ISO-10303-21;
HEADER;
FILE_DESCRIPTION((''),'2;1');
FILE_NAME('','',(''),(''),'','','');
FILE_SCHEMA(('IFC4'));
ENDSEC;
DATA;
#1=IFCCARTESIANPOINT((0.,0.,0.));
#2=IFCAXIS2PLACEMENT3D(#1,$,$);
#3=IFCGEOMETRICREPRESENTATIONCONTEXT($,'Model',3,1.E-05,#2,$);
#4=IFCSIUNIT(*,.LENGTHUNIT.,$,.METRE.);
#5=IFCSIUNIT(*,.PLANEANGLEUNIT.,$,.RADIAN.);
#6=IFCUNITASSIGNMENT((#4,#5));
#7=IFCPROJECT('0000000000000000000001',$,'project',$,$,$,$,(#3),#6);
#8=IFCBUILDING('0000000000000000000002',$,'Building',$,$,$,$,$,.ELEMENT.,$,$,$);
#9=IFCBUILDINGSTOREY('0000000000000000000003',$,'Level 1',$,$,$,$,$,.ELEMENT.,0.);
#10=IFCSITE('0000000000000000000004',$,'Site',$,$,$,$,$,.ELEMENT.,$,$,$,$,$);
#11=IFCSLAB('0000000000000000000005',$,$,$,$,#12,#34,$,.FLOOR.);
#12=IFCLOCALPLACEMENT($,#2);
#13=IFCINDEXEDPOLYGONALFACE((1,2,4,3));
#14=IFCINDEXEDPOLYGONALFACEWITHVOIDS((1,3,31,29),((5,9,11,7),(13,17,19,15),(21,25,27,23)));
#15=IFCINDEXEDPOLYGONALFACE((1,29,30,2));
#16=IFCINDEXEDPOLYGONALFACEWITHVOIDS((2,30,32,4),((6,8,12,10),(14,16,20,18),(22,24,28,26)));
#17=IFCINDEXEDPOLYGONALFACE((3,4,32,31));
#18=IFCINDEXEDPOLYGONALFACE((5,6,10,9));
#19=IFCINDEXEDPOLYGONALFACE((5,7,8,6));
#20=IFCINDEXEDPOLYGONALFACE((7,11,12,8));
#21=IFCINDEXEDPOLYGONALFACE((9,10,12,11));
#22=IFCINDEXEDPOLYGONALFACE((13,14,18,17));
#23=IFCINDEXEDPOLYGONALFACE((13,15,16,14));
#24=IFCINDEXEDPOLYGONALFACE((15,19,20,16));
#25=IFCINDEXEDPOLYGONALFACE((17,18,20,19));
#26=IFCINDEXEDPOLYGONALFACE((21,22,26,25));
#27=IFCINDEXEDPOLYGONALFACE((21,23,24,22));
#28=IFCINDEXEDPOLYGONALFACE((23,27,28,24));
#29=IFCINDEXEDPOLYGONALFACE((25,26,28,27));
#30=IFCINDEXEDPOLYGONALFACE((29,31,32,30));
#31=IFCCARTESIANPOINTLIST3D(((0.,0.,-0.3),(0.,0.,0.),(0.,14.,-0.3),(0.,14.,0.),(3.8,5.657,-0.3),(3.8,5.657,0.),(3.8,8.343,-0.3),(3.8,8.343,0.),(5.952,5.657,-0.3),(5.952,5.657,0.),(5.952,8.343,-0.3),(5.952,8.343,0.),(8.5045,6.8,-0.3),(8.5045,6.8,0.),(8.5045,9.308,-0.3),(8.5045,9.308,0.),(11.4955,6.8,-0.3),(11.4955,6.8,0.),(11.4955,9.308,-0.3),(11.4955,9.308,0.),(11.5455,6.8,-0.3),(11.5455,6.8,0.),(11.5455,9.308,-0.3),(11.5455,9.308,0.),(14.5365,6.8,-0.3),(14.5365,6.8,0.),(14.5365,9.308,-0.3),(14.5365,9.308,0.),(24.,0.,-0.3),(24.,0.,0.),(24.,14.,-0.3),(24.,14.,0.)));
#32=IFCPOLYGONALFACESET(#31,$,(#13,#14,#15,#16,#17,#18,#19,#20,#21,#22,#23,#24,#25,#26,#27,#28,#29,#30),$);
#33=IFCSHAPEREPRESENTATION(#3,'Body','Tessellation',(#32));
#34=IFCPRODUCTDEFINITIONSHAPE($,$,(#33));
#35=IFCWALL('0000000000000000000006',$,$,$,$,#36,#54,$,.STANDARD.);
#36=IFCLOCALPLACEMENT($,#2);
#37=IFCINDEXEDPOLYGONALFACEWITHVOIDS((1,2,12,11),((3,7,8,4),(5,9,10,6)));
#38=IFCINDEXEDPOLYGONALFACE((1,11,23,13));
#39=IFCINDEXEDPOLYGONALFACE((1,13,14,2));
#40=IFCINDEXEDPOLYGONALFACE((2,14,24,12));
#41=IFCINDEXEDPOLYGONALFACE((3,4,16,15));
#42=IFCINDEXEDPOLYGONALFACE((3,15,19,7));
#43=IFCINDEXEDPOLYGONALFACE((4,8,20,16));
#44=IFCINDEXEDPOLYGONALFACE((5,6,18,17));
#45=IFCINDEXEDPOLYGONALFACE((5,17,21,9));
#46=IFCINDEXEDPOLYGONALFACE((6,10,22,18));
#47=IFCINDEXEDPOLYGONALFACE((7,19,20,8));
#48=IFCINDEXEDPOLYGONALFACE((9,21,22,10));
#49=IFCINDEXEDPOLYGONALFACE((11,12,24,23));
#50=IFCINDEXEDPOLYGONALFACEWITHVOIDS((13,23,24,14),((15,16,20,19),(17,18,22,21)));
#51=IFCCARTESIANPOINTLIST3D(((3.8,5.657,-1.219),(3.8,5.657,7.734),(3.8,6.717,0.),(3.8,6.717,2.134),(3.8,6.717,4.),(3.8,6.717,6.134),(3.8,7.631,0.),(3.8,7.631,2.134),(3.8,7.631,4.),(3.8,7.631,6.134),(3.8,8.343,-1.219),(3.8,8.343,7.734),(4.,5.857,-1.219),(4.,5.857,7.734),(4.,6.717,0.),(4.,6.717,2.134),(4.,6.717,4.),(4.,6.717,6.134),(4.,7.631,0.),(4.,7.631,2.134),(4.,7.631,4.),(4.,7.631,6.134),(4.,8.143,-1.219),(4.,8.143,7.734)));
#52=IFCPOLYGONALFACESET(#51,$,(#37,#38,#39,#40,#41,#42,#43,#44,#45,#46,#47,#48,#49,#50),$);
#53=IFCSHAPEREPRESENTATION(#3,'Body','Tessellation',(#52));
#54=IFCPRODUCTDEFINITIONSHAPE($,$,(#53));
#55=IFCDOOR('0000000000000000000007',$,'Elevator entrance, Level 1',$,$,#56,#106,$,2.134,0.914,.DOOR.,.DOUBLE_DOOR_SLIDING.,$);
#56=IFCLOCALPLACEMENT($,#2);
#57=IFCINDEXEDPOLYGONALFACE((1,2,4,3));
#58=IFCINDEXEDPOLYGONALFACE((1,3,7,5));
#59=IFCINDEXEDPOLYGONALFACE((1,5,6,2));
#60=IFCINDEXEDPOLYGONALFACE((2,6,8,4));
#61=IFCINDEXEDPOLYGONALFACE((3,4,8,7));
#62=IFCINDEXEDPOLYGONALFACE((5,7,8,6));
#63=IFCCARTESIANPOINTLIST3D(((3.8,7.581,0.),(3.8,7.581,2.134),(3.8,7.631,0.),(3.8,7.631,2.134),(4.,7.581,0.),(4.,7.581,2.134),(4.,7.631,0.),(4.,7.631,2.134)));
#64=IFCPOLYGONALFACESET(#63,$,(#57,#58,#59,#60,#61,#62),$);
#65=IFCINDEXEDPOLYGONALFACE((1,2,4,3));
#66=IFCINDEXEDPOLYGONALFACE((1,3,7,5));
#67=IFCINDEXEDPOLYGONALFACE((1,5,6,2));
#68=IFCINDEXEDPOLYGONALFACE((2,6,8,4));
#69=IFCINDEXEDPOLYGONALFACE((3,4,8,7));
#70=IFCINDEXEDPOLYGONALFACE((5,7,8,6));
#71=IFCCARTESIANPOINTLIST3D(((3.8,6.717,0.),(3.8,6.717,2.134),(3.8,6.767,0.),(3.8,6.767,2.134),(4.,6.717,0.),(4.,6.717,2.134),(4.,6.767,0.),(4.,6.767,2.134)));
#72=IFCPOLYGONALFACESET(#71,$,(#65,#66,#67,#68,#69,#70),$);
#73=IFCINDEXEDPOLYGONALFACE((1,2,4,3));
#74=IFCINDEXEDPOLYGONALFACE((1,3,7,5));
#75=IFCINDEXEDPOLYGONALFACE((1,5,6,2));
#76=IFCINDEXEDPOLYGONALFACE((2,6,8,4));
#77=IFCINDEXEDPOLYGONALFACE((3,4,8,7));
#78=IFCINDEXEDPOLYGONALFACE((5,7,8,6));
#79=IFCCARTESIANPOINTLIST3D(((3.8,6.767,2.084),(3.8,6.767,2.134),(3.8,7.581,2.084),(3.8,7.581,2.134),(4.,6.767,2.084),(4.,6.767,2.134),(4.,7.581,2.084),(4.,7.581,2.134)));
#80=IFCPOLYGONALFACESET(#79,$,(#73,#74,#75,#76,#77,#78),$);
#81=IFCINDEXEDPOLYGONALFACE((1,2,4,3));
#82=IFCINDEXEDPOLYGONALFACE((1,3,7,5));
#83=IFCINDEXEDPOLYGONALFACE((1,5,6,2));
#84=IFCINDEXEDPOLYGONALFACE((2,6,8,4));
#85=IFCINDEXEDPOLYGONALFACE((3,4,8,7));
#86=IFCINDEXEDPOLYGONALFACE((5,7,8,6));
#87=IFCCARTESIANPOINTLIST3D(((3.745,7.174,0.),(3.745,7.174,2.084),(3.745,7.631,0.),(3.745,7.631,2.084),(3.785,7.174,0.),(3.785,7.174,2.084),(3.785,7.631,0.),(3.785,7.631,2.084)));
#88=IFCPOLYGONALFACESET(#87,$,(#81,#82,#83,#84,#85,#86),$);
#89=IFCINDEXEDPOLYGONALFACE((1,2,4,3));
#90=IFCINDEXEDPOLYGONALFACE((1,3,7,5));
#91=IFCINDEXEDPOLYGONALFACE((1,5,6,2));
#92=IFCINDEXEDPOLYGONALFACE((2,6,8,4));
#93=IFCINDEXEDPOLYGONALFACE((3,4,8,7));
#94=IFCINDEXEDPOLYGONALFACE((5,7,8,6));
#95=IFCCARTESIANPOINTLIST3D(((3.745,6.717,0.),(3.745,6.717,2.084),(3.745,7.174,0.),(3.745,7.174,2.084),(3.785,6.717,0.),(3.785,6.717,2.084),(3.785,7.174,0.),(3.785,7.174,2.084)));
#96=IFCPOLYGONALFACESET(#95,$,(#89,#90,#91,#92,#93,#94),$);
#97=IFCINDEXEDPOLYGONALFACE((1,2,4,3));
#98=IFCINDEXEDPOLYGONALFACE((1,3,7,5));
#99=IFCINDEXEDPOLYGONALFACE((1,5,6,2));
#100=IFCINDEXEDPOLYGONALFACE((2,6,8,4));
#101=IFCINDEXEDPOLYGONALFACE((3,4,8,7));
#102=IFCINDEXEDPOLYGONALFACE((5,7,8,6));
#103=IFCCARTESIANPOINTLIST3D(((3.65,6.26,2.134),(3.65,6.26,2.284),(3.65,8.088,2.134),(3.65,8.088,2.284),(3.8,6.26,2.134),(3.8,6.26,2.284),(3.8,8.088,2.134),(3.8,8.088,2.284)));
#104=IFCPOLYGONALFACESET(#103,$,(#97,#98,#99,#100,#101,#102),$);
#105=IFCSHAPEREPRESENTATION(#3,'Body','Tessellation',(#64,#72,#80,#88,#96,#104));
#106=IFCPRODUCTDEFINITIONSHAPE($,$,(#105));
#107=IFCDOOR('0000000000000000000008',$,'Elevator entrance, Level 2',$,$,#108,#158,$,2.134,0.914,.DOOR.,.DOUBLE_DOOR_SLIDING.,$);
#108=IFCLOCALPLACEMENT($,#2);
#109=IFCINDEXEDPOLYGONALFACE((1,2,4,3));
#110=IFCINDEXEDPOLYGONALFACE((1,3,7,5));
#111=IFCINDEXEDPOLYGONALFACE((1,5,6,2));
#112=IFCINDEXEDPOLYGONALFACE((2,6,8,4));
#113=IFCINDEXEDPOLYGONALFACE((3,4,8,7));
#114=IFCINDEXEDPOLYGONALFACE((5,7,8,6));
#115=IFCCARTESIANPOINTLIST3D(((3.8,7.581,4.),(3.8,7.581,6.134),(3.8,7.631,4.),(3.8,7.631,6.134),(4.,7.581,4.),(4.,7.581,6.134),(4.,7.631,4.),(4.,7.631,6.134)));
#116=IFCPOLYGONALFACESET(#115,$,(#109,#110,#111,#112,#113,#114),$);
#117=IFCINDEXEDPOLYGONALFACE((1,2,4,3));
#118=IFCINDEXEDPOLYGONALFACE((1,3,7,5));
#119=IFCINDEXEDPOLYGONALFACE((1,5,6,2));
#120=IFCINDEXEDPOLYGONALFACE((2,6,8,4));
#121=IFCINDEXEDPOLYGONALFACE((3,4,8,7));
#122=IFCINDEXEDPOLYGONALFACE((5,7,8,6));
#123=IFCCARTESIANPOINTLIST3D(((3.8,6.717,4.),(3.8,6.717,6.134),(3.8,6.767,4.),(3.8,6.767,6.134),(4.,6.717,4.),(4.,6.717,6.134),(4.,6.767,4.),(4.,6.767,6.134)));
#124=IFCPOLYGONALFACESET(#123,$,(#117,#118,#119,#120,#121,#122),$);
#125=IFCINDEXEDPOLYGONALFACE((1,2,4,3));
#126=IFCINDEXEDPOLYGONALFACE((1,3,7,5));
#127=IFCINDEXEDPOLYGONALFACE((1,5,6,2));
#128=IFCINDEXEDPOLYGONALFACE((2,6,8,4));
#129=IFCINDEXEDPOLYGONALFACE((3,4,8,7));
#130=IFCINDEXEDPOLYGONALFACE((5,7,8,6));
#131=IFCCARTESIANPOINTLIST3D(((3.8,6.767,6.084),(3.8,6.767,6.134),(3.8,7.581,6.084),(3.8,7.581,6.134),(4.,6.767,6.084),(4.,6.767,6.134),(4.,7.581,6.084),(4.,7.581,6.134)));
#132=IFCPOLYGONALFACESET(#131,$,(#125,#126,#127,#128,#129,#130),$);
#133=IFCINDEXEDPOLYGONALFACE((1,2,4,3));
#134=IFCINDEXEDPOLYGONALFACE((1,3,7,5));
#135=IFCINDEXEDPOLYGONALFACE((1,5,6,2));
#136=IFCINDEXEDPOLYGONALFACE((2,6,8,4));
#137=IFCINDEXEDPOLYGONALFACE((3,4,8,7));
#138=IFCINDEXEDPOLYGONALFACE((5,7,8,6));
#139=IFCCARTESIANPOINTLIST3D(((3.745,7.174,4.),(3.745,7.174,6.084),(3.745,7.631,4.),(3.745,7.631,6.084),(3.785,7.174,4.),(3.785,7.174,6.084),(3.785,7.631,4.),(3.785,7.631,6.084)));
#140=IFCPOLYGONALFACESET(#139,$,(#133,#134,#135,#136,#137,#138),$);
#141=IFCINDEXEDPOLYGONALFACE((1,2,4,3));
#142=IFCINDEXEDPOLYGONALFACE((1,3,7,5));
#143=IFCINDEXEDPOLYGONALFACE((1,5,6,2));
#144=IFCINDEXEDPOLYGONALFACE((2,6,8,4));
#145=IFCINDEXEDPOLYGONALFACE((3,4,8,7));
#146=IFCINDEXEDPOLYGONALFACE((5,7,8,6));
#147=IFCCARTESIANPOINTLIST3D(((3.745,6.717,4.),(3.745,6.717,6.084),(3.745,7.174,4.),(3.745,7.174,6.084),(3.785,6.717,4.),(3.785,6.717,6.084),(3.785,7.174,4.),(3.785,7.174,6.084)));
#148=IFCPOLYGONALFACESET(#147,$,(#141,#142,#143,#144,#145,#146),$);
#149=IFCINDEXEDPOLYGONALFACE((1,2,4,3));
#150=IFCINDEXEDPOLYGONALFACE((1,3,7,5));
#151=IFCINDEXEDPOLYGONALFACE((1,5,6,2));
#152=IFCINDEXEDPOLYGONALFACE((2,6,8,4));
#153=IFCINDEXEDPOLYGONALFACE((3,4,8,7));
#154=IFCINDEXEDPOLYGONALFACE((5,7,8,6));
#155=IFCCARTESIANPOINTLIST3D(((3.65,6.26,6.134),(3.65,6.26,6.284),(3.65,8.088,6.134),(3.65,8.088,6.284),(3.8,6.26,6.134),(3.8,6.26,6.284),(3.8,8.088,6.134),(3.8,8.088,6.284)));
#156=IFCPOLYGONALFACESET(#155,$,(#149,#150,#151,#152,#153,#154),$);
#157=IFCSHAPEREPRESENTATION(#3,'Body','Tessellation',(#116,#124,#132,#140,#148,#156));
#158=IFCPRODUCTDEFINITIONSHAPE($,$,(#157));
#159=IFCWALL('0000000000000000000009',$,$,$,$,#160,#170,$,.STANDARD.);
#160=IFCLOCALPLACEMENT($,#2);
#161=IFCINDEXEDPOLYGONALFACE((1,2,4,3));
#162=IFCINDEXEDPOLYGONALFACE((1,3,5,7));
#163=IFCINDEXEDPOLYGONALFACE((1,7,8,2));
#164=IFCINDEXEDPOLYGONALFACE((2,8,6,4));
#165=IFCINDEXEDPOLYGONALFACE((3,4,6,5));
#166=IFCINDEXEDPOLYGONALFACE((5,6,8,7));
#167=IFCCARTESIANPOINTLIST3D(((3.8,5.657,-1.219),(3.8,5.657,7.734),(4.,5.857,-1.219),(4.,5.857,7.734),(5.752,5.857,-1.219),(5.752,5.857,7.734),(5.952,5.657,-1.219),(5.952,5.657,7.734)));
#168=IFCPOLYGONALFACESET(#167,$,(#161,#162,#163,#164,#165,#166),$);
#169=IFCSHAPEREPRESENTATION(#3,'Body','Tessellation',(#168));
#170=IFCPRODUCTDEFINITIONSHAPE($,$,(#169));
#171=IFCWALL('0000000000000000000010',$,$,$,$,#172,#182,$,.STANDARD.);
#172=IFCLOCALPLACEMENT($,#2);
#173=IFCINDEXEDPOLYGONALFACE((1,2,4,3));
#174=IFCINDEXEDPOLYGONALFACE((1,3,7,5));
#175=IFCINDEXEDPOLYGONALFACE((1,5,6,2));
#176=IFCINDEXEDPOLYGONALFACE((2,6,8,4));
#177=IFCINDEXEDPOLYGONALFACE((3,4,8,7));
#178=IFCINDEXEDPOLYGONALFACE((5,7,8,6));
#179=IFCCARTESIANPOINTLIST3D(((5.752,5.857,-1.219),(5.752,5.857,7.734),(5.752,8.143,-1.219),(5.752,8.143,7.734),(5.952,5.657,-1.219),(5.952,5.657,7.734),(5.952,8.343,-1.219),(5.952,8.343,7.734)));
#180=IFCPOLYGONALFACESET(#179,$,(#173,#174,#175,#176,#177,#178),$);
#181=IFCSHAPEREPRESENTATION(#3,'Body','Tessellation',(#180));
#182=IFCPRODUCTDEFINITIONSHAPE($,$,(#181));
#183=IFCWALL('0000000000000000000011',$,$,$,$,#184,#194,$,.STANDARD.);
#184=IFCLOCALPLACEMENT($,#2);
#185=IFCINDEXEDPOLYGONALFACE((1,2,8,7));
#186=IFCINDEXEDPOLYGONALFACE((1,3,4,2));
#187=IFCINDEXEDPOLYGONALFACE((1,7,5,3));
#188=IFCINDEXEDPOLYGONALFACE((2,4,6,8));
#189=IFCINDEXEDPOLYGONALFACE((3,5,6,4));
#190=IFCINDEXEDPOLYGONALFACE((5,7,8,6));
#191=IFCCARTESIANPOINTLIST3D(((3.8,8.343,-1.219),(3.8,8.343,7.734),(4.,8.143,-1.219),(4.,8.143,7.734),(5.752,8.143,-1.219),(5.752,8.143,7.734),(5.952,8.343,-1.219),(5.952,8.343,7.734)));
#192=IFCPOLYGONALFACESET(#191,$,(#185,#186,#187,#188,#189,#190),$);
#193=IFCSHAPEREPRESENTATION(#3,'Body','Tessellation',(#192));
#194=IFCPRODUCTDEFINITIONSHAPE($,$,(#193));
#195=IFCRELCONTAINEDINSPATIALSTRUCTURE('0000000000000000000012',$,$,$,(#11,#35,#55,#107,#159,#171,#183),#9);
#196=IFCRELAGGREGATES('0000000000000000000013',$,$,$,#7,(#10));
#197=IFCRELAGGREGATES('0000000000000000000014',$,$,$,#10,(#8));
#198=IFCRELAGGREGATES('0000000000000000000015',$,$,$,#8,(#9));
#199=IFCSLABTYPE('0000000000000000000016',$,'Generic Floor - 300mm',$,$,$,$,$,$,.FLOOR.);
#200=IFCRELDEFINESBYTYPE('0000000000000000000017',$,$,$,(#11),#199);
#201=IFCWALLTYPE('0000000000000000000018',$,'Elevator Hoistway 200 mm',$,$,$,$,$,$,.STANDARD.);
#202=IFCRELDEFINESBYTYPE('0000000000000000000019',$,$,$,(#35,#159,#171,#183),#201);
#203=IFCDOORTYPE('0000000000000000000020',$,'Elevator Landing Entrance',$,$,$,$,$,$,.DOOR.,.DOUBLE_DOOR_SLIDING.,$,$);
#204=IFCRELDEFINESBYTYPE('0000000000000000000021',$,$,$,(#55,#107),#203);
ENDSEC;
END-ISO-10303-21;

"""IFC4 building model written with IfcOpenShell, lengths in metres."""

from ifc_helpers import new_model, si_unit, frame, frame_2d, origin, origin_with_axes, origin_2d, place, context, project, spatial, polyline, rectangle, outline, extrude, type_object, element, fill, save


model = new_model("IFC4")

# Units and contexts
model_context = context("Model", 3, precision=1e-05, world=origin())
ifc_project = project(units=[si_unit("LENGTHUNIT", "METRE"), si_unit("PLANEANGLEUNIT", "RADIAN")], contexts=[model_context])

# Site, building, storey
site = spatial("IfcSite", under=ifc_project, Name="Site", CompositionType="ELEMENT")
building = spatial("IfcBuilding", under=site, Name="Building", CompositionType="ELEMENT")
storey = spatial("IfcBuildingStorey", under=building, Name="Level 1", CompositionType="ELEMENT", Elevation=0.0)

# Slab, openings
slab_type = type_object("IfcSlabType", Name="Generic Floor - 300mm", PredefinedType="FLOOR")
slab_placement = place(None, origin())
slab = element("IfcSlab", 1, at=slab_placement, inside=storey, type_object=slab_type, PredefinedType="FLOOR", context=model_context, shape_type="SweptSolid", body=[
    extrude(outline(polyline([(0.0, 0.0), (24.0, 0.0), (24.0, 14.0), (0.0, 14.0), (0.0, 0.0)])), origin(), (0.0, 0.0, -1.0), 0.3),
])
opening_1_placement = place(None, frame((0.0, 0.0, 0.001)))
element("IfcOpeningElement", 2, at=opening_1_placement, cuts=slab, PredefinedType="OPENING", context=model_context, shape_type="SweptSolid", body=[
    extrude(outline(polyline([(8.5045, 6.8), (11.4955, 6.8), (11.4955, 9.308), (8.5045, 9.308), (8.5045, 6.8)])), origin(), (0.0, 0.0, -1.0), 0.302),
])
opening_2_placement = place(None, frame((0.0, 0.0, 0.001)))
element("IfcOpeningElement", 3, at=opening_2_placement, cuts=slab, PredefinedType="OPENING", context=model_context, shape_type="SweptSolid", body=[
    extrude(outline(polyline([(11.5455, 6.8), (14.5365, 6.8), (14.5365, 9.308), (11.5455, 9.308), (11.5455, 6.8)])), origin(), (0.0, 0.0, -1.0), 0.302),
])
opening_3_placement = place(None, frame((0.0, 0.0, 0.001)))
element("IfcOpeningElement", 4, at=opening_3_placement, cuts=slab, PredefinedType="OPENING", context=model_context, shape_type="SweptSolid", body=[
    extrude(outline(polyline([(3.8, 8.343), (3.8, 5.657), (5.952, 5.657), (5.952, 8.343), (3.8, 8.343)])), origin(), (0.0, 0.0, -1.0), 0.302),
])

# Wall, openings, doors
wall_type = type_object("IfcWallType", Name="Elevator Hoistway 200 mm", PredefinedType="STANDARD")
wall_1_placement = place(None, frame((3.9, 8.243, -1.219), z_axis=(0.0, 0.0, 1.0), x_axis=(0.0, -1.0, 0.0)))
wall_1 = element("IfcWall", 5, at=wall_1_placement, inside=storey, type_object=wall_type, PredefinedType="STANDARD", context=model_context, shape_type="SweptSolid", body=[
    extrude(outline(polyline([(-0.1, -0.1), (2.586, -0.1), (2.386, 0.1), (0.1, 0.1), (-0.1, -0.1)])), origin(), (0.0, 0.0, 1.0), 8.953),
])
opening_4_placement = place(wall_1_placement, frame((1.069, 0.0, 1.219), z_axis=(0.0, 0.0, 1.0), x_axis=(1.0, 0.0, 0.0)))
opening_4 = element("IfcOpeningElement", 6, at=opening_4_placement, cuts=wall_1, PredefinedType="OPENING", context=model_context, shape_type="SweptSolid", body=[
    extrude(rectangle(XDim=0.914, YDim=0.202, at=origin_2d()), origin(), (0.0, 0.0, 1.0), 2.134),
])
opening_5_placement = place(wall_1_placement, frame((1.069, 0.0, 5.219), z_axis=(0.0, 0.0, 1.0), x_axis=(1.0, 0.0, 0.0)))
opening_5 = element("IfcOpeningElement", 7, at=opening_5_placement, cuts=wall_1, PredefinedType="OPENING", context=model_context, shape_type="SweptSolid", body=[
    extrude(rectangle(XDim=0.914, YDim=0.202, at=origin_2d()), origin(), (0.0, 0.0, 1.0), 2.134),
])
door_type = type_object("IfcDoorType", Name="Elevator Landing Entrance", OperationType="DOUBLE_DOOR_SLIDING", PredefinedType="DOOR")
door_1_placement = place(opening_4_placement, origin_with_axes())
door_1 = element("IfcDoor", 8, at=door_1_placement, inside=storey, type_object=door_type, Name="Elevator entrance, Level 1", OperationType="DOUBLE_DOOR_SLIDING", OverallHeight=2.134, OverallWidth=0.914, PredefinedType="DOOR", context=model_context, shape_type="SweptSolid", body=[
    extrude(rectangle(XDim=0.05, YDim=0.2, at=frame_2d((-0.432, 0.0))), origin(), (0.0, 0.0, 1.0), 2.134),
    extrude(rectangle(XDim=0.05, YDim=0.2, at=frame_2d((0.432, 0.0))), origin(), (0.0, 0.0, 1.0), 2.134),
    extrude(rectangle(XDim=0.814, YDim=0.2, at=origin_2d()), frame((0.0, 0.0, 2.084)), (0.0, 0.0, 1.0), 0.05),
    extrude(rectangle(XDim=0.457, YDim=0.04, at=frame_2d((-0.2285, -0.135))), origin(), (0.0, 0.0, 1.0), 2.084),
    extrude(rectangle(XDim=0.457, YDim=0.04, at=frame_2d((0.2285, -0.135))), origin(), (0.0, 0.0, 1.0), 2.084),
    extrude(rectangle(XDim=1.828, YDim=0.15, at=frame_2d((0.0, -0.175))), frame((0.0, 0.0, 2.134)), (0.0, 0.0, 1.0), 0.15),
])
fill(opening_4, door_1)
door_2_placement = place(opening_5_placement, origin_with_axes())
door_2 = element("IfcDoor", 9, at=door_2_placement, inside=storey, type_object=door_type, Name="Elevator entrance, Level 2", OperationType="DOUBLE_DOOR_SLIDING", OverallHeight=2.134, OverallWidth=0.914, PredefinedType="DOOR", context=model_context, shape_type="SweptSolid", body=[
    extrude(rectangle(XDim=0.05, YDim=0.2, at=frame_2d((-0.432, 0.0))), origin(), (0.0, 0.0, 1.0), 2.134),
    extrude(rectangle(XDim=0.05, YDim=0.2, at=frame_2d((0.432, 0.0))), origin(), (0.0, 0.0, 1.0), 2.134),
    extrude(rectangle(XDim=0.814, YDim=0.2, at=origin_2d()), frame((0.0, 0.0, 2.084)), (0.0, 0.0, 1.0), 0.05),
    extrude(rectangle(XDim=0.457, YDim=0.04, at=frame_2d((-0.2285, -0.135))), origin(), (0.0, 0.0, 1.0), 2.084),
    extrude(rectangle(XDim=0.457, YDim=0.04, at=frame_2d((0.2285, -0.135))), origin(), (0.0, 0.0, 1.0), 2.084),
    extrude(rectangle(XDim=1.828, YDim=0.15, at=frame_2d((0.0, -0.175))), frame((0.0, 0.0, 2.134)), (0.0, 0.0, 1.0), 0.15),
])
fill(opening_5, door_2)

# Walls
wall_2_placement = place(None, frame((3.9, 5.757, -1.219), z_axis=(0.0, 0.0, 1.0), x_axis=(1.0, 0.0, 0.0)))
element("IfcWall", 10, at=wall_2_placement, inside=storey, type_object=wall_type, PredefinedType="STANDARD", context=model_context, shape_type="SweptSolid", body=[
    extrude(outline(polyline([(-0.1, -0.1), (2.052, -0.1), (1.852, 0.1), (0.1, 0.1), (-0.1, -0.1)])), origin(), (0.0, 0.0, 1.0), 8.953),
])
wall_3_placement = place(None, frame((5.852, 5.757, -1.219), z_axis=(0.0, 0.0, 1.0), x_axis=(0.0, 1.0, 0.0)))
element("IfcWall", 11, at=wall_3_placement, inside=storey, type_object=wall_type, PredefinedType="STANDARD", context=model_context, shape_type="SweptSolid", body=[
    extrude(outline(polyline([(-0.1, -0.1), (2.586, -0.1), (2.386, 0.1), (0.1, 0.1), (-0.1, -0.1)])), origin(), (0.0, 0.0, 1.0), 8.953),
])
wall_4_placement = place(None, frame((5.852, 8.243, -1.219), z_axis=(0.0, 0.0, 1.0), x_axis=(-1.0, 0.0, 0.0)))
element("IfcWall", 12, at=wall_4_placement, inside=storey, type_object=wall_type, PredefinedType="STANDARD", context=model_context, shape_type="SweptSolid", body=[
    extrude(outline(polyline([(-0.1, -0.1), (2.052, -0.1), (1.852, 0.1), (0.1, 0.1), (-0.1, -0.1)])), origin(), (0.0, 0.0, 1.0), 8.953),
])

save(model, "model.ifc")
